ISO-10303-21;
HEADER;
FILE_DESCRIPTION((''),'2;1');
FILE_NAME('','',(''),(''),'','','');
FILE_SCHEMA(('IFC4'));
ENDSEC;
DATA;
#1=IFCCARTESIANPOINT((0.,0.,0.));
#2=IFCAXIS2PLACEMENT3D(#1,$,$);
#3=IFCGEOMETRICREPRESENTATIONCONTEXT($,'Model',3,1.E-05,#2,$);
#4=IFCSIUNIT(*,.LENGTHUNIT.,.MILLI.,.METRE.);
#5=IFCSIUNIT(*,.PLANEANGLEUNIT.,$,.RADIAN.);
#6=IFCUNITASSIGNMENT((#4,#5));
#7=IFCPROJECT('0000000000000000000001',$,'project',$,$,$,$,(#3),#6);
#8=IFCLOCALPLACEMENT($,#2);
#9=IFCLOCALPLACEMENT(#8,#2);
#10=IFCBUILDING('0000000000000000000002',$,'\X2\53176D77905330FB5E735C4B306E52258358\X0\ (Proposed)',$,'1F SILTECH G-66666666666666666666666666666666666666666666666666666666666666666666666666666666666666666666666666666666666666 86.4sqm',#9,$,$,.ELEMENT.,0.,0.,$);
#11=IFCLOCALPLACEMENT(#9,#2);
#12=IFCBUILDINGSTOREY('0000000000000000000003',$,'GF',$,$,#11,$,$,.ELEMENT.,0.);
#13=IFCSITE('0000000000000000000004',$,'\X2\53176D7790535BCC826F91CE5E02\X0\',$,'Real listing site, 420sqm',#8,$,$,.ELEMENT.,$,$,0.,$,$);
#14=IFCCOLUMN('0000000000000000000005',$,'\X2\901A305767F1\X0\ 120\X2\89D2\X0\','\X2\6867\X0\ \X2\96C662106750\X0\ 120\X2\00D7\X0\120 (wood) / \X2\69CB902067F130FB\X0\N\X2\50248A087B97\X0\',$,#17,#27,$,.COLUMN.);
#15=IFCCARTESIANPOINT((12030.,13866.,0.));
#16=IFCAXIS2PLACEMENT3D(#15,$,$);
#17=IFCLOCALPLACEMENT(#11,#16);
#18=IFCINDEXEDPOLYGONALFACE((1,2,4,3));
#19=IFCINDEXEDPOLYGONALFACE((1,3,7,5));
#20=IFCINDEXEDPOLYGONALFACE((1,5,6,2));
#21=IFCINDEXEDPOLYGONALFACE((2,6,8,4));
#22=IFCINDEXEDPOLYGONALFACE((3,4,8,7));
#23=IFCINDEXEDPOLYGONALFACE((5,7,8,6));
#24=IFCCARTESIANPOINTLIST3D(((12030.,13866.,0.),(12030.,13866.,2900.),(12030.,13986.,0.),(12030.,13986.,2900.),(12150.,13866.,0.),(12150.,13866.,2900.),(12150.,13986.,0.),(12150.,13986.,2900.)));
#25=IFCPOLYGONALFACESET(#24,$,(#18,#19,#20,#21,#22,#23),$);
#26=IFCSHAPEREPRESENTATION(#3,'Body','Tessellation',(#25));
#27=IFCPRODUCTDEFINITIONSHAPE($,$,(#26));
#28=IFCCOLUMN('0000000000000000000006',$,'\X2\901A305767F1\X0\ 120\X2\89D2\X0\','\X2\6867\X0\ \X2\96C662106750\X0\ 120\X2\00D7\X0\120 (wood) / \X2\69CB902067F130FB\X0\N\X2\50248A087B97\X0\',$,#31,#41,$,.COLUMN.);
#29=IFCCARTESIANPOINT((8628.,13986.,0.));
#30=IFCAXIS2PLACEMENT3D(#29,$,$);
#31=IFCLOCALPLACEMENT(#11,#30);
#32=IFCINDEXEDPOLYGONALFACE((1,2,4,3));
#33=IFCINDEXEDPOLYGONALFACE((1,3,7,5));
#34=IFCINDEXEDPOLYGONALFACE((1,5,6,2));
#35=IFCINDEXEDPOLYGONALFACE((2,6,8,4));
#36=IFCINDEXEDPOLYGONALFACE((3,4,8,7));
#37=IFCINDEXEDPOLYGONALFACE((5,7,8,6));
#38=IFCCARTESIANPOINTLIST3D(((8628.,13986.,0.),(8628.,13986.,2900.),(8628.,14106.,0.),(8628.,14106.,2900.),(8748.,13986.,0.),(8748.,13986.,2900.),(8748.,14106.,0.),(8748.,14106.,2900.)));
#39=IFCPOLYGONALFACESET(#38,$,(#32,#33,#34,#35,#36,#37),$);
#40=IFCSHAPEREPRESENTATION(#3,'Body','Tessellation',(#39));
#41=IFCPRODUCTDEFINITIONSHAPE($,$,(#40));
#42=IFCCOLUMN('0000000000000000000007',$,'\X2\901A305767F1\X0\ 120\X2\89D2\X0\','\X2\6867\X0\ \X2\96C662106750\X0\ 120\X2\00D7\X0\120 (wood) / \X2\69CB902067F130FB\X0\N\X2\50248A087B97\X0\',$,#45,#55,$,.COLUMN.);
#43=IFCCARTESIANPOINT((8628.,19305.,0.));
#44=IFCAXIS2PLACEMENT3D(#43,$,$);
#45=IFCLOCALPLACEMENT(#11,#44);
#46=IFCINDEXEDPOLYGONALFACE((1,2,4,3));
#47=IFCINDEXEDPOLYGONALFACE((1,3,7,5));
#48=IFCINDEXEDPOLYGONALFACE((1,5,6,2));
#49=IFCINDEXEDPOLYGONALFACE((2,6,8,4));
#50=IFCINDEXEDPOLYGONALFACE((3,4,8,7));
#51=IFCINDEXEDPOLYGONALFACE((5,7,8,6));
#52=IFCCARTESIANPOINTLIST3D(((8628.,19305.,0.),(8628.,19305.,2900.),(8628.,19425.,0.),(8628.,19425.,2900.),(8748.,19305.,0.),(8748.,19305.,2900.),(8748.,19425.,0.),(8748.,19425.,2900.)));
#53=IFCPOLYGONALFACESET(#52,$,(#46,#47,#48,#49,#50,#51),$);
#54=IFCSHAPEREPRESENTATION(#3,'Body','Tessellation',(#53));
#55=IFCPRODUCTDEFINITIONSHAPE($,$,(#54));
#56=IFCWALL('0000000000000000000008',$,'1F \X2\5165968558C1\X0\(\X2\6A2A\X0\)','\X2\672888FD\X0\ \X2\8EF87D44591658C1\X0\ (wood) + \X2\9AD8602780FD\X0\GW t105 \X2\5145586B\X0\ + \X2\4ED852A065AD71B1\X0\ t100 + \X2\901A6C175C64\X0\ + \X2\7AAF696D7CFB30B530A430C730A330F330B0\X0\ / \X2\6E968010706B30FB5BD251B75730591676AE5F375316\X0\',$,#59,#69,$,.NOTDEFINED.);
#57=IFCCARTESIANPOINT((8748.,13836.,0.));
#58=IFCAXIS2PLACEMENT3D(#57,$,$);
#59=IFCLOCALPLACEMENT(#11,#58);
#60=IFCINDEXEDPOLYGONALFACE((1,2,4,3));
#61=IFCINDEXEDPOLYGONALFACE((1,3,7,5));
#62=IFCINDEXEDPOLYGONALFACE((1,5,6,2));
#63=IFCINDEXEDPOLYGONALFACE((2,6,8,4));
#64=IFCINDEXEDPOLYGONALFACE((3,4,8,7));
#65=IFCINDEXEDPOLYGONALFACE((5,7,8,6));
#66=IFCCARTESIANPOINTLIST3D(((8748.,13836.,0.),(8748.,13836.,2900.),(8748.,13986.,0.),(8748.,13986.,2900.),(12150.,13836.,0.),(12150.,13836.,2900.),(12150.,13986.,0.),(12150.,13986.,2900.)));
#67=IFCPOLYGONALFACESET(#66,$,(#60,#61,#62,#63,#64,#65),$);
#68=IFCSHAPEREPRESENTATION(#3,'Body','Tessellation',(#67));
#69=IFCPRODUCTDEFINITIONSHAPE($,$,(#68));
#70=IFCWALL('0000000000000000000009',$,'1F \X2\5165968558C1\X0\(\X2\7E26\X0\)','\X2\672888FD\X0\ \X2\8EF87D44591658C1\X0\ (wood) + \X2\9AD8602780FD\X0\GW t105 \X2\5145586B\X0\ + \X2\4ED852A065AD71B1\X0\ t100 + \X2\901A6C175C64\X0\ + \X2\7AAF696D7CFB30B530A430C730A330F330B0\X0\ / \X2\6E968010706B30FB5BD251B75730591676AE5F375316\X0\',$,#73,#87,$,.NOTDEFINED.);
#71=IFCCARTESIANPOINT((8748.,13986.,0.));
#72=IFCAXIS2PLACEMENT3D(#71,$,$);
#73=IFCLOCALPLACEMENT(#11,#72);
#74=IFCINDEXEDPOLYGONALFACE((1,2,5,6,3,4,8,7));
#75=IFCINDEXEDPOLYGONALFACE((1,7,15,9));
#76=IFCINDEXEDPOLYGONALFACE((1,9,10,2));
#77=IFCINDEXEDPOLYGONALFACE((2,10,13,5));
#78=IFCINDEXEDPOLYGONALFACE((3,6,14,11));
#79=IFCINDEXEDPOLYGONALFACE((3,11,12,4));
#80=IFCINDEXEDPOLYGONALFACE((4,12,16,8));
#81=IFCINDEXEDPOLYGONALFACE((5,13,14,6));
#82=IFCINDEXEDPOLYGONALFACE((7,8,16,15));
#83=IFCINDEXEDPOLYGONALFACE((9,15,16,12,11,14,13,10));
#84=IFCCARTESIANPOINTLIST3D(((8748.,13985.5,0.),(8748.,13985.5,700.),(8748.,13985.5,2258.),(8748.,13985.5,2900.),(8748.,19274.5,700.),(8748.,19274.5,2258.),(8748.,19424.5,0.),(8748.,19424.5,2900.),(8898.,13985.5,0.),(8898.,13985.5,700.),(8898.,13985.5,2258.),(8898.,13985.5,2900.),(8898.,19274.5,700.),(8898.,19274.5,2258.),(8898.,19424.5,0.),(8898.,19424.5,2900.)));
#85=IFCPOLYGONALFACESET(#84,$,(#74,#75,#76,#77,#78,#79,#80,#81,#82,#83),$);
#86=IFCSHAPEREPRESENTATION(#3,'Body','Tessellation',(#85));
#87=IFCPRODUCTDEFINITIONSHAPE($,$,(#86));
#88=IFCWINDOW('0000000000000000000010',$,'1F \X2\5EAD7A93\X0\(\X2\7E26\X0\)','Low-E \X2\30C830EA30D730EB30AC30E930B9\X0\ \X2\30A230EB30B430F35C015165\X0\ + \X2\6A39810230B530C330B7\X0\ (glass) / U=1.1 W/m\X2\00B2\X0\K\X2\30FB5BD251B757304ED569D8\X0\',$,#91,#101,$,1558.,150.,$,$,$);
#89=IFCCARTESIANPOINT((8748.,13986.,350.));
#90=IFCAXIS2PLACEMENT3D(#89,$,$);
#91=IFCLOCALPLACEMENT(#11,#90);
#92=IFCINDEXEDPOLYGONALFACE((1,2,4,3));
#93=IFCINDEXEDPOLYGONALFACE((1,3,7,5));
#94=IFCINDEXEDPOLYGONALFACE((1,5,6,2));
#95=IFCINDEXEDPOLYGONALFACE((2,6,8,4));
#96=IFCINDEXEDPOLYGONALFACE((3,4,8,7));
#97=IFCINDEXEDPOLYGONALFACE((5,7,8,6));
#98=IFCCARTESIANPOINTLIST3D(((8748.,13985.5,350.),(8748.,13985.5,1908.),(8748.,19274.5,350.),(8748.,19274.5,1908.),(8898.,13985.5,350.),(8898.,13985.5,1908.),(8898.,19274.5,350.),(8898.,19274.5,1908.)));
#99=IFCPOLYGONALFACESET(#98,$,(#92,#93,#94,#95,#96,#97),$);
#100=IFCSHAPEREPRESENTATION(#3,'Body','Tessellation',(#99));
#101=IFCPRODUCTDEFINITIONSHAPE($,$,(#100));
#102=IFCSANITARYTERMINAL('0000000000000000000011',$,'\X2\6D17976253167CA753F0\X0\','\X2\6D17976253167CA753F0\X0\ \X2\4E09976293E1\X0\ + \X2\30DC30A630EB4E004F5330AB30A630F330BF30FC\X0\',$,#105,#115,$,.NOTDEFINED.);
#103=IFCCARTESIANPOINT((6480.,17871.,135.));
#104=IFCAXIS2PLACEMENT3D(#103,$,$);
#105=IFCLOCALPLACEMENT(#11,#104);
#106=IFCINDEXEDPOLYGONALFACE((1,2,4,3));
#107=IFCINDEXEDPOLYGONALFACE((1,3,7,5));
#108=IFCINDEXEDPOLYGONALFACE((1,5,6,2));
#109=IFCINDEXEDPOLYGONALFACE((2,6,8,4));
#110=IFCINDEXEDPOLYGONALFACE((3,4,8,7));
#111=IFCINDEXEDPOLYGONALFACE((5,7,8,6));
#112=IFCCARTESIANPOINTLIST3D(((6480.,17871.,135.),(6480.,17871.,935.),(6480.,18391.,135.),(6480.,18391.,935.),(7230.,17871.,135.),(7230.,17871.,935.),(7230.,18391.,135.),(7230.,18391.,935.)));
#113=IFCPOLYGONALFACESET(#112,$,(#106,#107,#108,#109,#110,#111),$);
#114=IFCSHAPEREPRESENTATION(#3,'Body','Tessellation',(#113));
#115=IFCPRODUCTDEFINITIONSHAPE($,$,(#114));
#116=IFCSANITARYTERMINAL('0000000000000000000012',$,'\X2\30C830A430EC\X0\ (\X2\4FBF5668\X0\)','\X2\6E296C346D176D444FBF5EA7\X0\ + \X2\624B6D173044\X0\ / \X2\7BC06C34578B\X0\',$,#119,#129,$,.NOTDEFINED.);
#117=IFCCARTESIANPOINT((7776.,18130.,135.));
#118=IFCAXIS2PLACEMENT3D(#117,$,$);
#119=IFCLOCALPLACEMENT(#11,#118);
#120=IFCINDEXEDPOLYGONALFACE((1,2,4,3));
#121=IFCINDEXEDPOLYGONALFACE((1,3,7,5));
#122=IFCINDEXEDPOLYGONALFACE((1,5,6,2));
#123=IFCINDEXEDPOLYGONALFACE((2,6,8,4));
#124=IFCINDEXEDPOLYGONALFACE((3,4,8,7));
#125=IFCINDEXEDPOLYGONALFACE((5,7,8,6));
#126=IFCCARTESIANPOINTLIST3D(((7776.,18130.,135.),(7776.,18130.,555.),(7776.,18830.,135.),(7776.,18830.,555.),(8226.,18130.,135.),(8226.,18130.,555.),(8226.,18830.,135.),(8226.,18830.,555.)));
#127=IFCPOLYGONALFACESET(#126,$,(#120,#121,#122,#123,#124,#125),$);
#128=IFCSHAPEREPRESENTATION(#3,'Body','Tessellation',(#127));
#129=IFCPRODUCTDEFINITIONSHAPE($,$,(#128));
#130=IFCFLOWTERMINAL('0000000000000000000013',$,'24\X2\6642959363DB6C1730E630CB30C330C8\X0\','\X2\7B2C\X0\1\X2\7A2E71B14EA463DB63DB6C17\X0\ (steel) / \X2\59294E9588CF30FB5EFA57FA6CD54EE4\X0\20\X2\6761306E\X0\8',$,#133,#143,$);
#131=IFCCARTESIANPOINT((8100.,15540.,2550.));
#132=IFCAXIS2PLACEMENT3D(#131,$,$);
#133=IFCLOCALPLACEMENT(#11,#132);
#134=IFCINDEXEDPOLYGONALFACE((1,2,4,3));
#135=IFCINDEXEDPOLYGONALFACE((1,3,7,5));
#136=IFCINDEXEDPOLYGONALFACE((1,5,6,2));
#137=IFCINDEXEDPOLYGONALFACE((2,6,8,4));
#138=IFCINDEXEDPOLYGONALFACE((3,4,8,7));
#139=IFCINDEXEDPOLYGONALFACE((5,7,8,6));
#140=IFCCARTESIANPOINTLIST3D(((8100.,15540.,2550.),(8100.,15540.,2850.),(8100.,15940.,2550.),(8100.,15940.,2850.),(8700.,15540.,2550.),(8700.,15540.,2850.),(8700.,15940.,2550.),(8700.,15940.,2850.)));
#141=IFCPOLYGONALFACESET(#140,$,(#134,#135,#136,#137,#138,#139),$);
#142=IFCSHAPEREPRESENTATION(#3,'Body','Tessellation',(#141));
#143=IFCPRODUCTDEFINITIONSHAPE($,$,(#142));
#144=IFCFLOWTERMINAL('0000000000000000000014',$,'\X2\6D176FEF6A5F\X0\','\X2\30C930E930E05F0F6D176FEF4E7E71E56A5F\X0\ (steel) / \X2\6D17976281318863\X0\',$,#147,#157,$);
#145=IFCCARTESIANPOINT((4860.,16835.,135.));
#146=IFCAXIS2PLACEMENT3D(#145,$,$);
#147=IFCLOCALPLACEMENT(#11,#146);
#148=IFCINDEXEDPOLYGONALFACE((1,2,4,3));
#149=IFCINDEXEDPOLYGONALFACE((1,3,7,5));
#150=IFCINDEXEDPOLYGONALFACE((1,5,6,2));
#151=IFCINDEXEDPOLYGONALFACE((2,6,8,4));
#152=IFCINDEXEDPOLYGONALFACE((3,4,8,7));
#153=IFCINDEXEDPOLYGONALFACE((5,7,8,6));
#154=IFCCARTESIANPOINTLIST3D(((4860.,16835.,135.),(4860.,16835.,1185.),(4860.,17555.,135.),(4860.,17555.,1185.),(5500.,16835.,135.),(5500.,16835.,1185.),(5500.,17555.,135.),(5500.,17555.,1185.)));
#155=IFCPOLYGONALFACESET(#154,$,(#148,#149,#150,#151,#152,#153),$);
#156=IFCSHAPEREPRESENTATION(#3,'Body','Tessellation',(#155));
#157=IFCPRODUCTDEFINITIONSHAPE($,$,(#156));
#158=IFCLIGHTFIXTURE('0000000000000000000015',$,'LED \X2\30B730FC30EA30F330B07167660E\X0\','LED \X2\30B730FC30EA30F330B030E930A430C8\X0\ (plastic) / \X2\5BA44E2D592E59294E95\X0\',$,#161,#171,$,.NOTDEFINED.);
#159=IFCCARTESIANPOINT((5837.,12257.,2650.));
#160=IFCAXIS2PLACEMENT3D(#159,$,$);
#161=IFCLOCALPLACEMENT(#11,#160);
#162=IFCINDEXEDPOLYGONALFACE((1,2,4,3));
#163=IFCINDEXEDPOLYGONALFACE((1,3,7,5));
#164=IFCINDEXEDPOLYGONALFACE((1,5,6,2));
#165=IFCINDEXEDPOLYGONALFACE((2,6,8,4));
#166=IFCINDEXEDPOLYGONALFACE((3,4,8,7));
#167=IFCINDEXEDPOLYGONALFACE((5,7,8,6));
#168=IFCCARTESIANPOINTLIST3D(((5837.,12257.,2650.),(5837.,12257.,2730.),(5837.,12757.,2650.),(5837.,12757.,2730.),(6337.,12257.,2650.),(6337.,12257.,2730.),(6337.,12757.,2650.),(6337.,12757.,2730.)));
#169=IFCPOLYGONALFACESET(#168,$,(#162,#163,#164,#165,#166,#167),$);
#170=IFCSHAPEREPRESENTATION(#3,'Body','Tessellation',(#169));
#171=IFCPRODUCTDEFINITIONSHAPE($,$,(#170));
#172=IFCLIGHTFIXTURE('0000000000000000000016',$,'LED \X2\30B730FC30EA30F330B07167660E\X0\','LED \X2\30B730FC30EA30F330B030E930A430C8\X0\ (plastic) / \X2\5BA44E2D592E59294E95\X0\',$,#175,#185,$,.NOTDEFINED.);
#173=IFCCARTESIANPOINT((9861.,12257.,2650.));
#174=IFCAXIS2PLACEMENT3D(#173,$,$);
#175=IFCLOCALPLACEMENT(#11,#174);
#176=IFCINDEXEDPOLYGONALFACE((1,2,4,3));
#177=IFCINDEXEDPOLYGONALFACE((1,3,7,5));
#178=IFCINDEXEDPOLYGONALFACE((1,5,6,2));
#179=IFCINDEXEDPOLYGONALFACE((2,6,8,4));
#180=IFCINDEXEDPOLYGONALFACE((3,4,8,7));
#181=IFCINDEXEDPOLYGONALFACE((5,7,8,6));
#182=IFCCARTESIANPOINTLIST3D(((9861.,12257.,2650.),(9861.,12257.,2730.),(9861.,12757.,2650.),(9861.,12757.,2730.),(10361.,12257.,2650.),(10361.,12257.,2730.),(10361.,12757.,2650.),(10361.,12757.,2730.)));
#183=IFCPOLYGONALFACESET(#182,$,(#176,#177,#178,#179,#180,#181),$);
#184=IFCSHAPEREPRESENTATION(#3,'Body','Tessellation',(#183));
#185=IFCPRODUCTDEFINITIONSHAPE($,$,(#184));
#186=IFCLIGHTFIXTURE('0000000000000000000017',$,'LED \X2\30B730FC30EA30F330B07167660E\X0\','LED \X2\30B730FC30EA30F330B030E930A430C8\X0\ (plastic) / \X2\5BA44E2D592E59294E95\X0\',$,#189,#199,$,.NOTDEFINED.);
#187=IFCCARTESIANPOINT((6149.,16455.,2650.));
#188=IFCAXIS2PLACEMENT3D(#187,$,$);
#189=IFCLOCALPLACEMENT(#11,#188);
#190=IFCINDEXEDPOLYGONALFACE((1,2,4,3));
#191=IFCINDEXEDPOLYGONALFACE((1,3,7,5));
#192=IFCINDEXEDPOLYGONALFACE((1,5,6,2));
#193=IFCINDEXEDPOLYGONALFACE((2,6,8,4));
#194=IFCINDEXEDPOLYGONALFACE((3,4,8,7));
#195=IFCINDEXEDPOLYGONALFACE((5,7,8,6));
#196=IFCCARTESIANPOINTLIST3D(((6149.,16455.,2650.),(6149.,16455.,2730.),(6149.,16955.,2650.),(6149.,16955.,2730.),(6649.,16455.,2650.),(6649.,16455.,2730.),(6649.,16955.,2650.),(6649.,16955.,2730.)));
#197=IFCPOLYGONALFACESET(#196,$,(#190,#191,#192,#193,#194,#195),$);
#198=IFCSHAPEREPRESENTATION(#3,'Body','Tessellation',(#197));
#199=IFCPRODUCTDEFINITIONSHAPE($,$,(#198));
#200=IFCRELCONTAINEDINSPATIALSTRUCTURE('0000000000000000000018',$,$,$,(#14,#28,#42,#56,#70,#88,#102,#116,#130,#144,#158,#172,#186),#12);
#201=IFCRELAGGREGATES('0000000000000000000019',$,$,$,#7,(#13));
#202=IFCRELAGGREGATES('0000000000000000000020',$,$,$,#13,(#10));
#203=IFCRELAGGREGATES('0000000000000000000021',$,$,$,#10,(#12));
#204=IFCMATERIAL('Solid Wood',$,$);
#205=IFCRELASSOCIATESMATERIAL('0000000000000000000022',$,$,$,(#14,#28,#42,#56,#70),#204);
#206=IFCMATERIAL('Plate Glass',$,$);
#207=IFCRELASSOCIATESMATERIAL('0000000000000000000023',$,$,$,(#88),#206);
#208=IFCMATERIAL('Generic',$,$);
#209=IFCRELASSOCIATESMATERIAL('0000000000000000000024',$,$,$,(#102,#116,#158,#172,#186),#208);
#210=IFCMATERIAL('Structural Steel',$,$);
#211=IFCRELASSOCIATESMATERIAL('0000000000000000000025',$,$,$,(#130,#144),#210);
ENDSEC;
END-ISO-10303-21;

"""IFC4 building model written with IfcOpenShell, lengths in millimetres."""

from ifc_helpers import new_model, si_unit, frame, frame_2d, origin, place, context, project, spatial, rectangle, extrude, material, element, fill, save


model = new_model("IFC4")

# Units and contexts
model_context = context("Model", 3, precision=1e-05, world=origin())
ifc_project = project(units=[si_unit("LENGTHUNIT", "METRE", prefix="MILLI"), si_unit("PLANEANGLEUNIT", "RADIAN")], contexts=[model_context])

# Site, building, storey
site_placement = place(None, origin())
site = spatial("IfcSite", under=ifc_project, at=site_placement, Name="北海道富良野市", ObjectType="Real listing site, 420sqm", CompositionType="ELEMENT", RefElevation=0.0)
building_placement = place(site_placement, origin())
building = spatial("IfcBuilding", under=site, at=building_placement, Name="北海道・平屋の別荘 (Proposed)", ObjectType="1F SILTECH G-66666666666666666666666666666666666666666666666666666666666666666666666666666666666666666666666666666666666666 86.4sqm", CompositionType="ELEMENT", ElevationOfRefHeight=0.0, ElevationOfTerrain=0.0)
storey_placement = place(building_placement, origin())
storey = spatial("IfcBuildingStorey", under=building, at=storey_placement, Name="GF", CompositionType="ELEMENT", Elevation=0.0)

# Columns
ifc_material_1 = material(Name="Solid Wood")
column_1_placement = place(storey_placement, frame((12030.0, 13866.0, 0.0)))
element("IfcColumn", 1, at=column_1_placement, inside=storey, material=ifc_material_1, Name="通し柱 120角", Description="桧 集成材 120×120 (wood) / 構造柱・N値計算", PredefinedType="COLUMN", context=model_context, shape_type="SweptSolid", body=[
    extrude(rectangle(XDim=120.0, YDim=120.0, at=frame_2d((60.0, 60.0))), frame((12030.0, 13866.0, 0.0)), (0.0, 0.0, 1.0), 2900.0),
])
column_2_placement = place(storey_placement, frame((8628.0, 13986.0, 0.0)))
element("IfcColumn", 2, at=column_2_placement, inside=storey, material=ifc_material_1, Name="通し柱 120角", Description="桧 集成材 120×120 (wood) / 構造柱・N値計算", PredefinedType="COLUMN", context=model_context, shape_type="SweptSolid", body=[
    extrude(rectangle(XDim=120.0, YDim=120.0, at=frame_2d((60.0, 60.0))), frame((8628.0, 13986.0, 0.0)), (0.0, 0.0, 1.0), 2900.0),
])
column_3_placement = place(storey_placement, frame((8628.0, 19305.0, 0.0)))
element("IfcColumn", 3, at=column_3_placement, inside=storey, material=ifc_material_1, Name="通し柱 120角", Description="桧 集成材 120×120 (wood) / 構造柱・N値計算", PredefinedType="COLUMN", context=model_context, shape_type="SweptSolid", body=[
    extrude(rectangle(XDim=120.0, YDim=120.0, at=frame_2d((60.0, 60.0))), frame((8628.0, 19305.0, 0.0)), (0.0, 0.0, 1.0), 2900.0),
])

# Wall
wall_1_placement = place(storey_placement, frame((8748.0, 13836.0, 0.0)))
element("IfcWall", 4, at=wall_1_placement, inside=storey, material=ifc_material_1, Name="1F 入隅壁(横)", Description="木製 軸組外壁 (wood) + 高性能GW t105 充填 + 付加断熱 t100 + 通気層 + 窯業系サイディング / 準耐火・寒冷地外皮強化", PredefinedType="NOTDEFINED", context=model_context, shape_type="SweptSolid", body=[
    extrude(rectangle(XDim=3402.0, YDim=150.0, at=frame_2d((1701.0, 75.0))), frame((8748.0, 13836.0, 0.0)), (0.0, 0.0, 1.0), 2900.0),
])

# Wall, opening, window
wall_2_placement = place(storey_placement, frame((8748.0, 13986.0, 0.0)))
wall_2 = element("IfcWall", 5, at=wall_2_placement, inside=storey, material=ifc_material_1, Name="1F 入隅壁(縦)", Description="木製 軸組外壁 (wood) + 高性能GW t105 充填 + 付加断熱 t100 + 通気層 + 窯業系サイディング / 準耐火・寒冷地外皮強化", PredefinedType="NOTDEFINED", context=model_context, shape_type="SweptSolid", body=[
    extrude(rectangle(XDim=150.0, YDim=5439.0, at=frame_2d((75.0, 2719.0))), frame((8748.0, 13986.0, 0.0)), (0.0, 0.0, 1.0), 2900.0),
])
opening_placement = place(storey_placement, frame((8748.0, 13986.0, 350.0)))
opening = element("IfcOpeningElement", 6, at=opening_placement, cuts=wall_2, PredefinedType="NOTDEFINED", context=model_context, shape_type="SweptSolid", body=[
    extrude(rectangle(XDim=150.0, YDim=5289.0, at=frame_2d((75.0, 2644.0))), frame((8748.0, 13986.0, 350.0)), (0.0, 0.0, 1.0), 1558.0),
])
ifc_material_2 = material(Name="Plate Glass")
window_placement = place(storey_placement, frame((8748.0, 13986.0, 350.0)))
window = element("IfcWindow", 7, at=window_placement, inside=storey, material=ifc_material_2, Name="1F 庭窓(縦)", Description="Low-E トリプルガラス アルゴン封入 + 樹脂サッシ (glass) / U=1.1 W/m²K・寒冷地仕様", OverallHeight=1558.0, OverallWidth=150.0, context=model_context, shape_type="SweptSolid", body=[
    extrude(rectangle(XDim=150.0, YDim=5289.0, at=frame_2d((75.0, 2644.0))), frame((8748.0, 13986.0, 350.0)), (0.0, 0.0, 1.0), 1558.0),
])
fill(opening, window)

# Sanitary terminals
ifc_material_3 = material(Name="Generic")
sanitary_terminal_1_placement = place(storey_placement, frame((6480.0, 17871.0, 135.0)))
element("IfcSanitaryTerminal", 8, at=sanitary_terminal_1_placement, inside=storey, material=ifc_material_3, Name="洗面化粧台", Description="洗面化粧台 三面鏡 + ボウル一体カウンター", PredefinedType="NOTDEFINED", context=model_context, shape_type="SweptSolid", body=[
    extrude(rectangle(XDim=750.0, YDim=520.0, at=frame_2d((375.0, 260.0))), frame((6480.0, 17871.0, 135.0)), (0.0, 0.0, 1.0), 800.0),
])
sanitary_terminal_2_placement = place(storey_placement, frame((7776.0, 18130.0, 135.0)))
element("IfcSanitaryTerminal", 9, at=sanitary_terminal_2_placement, inside=storey, material=ifc_material_3, Name="トイレ (便器)", Description="温水洗浄便座 + 手洗い / 節水型", PredefinedType="NOTDEFINED", context=model_context, shape_type="SweptSolid", body=[
    extrude(rectangle(XDim=450.0, YDim=700.0, at=frame_2d((225.0, 350.0))), frame((7776.0, 18130.0, 135.0)), (0.0, 0.0, 1.0), 420.0),
])

# Flow terminals
ifc_material_4 = material(Name="Structural Steel")
flow_terminal_1_placement = place(storey_placement, frame((8100.0, 15540.0, 2550.0)))
element("IfcFlowTerminal", 10, at=flow_terminal_1_placement, inside=storey, material=ifc_material_4, Name="24時間換気ユニット", Description="第1種熱交換換気 (steel) / 天井裏・建基法令20条の8", context=model_context, shape_type="SweptSolid", body=[
    extrude(rectangle(XDim=600.0, YDim=400.0, at=frame_2d((300.0, 200.0))), frame((8100.0, 15540.0, 2550.0)), (0.0, 0.0, 1.0), 300.0),
])
flow_terminal_2_placement = place(storey_placement, frame((4860.0, 16835.0, 135.0)))
element("IfcFlowTerminal", 11, at=flow_terminal_2_placement, inside=storey, material=ifc_material_4, Name="洗濯機", Description="ドラム式洗濯乾燥機 (steel) / 洗面脱衣", context=model_context, shape_type="SweptSolid", body=[
    extrude(rectangle(XDim=640.0, YDim=720.0, at=frame_2d((320.0, 360.0))), frame((4860.0, 16835.0, 135.0)), (0.0, 0.0, 1.0), 1050.0),
])

# Light fixtures
light_fixture_1_placement = place(storey_placement, frame((5837.0, 12257.0, 2650.0)))
element("IfcLightFixture", 12, at=light_fixture_1_placement, inside=storey, material=ifc_material_3, Name="LED シーリング照明", Description="LED シーリングライト (plastic) / 室中央天井", PredefinedType="NOTDEFINED", context=model_context, shape_type="SweptSolid", body=[
    extrude(rectangle(XDim=500.0, YDim=500.0, at=frame_2d((250.0, 250.0))), frame((5837.0, 12257.0, 2650.0)), (0.0, 0.0, 1.0), 80.0),
])
light_fixture_2_placement = place(storey_placement, frame((9861.0, 12257.0, 2650.0)))
element("IfcLightFixture", 13, at=light_fixture_2_placement, inside=storey, material=ifc_material_3, Name="LED シーリング照明", Description="LED シーリングライト (plastic) / 室中央天井", PredefinedType="NOTDEFINED", context=model_context, shape_type="SweptSolid", body=[
    extrude(rectangle(XDim=500.0, YDim=500.0, at=frame_2d((250.0, 250.0))), frame((9861.0, 12257.0, 2650.0)), (0.0, 0.0, 1.0), 80.0),
])
light_fixture_3_placement = place(storey_placement, frame((6149.0, 16455.0, 2650.0)))
element("IfcLightFixture", 14, at=light_fixture_3_placement, inside=storey, material=ifc_material_3, Name="LED シーリング照明", Description="LED シーリングライト (plastic) / 室中央天井", PredefinedType="NOTDEFINED", context=model_context, shape_type="SweptSolid", body=[
    extrude(rectangle(XDim=500.0, YDim=500.0, at=frame_2d((250.0, 250.0))), frame((6149.0, 16455.0, 2650.0)), (0.0, 0.0, 1.0), 80.0),
])

save(model, "model.ifc")
